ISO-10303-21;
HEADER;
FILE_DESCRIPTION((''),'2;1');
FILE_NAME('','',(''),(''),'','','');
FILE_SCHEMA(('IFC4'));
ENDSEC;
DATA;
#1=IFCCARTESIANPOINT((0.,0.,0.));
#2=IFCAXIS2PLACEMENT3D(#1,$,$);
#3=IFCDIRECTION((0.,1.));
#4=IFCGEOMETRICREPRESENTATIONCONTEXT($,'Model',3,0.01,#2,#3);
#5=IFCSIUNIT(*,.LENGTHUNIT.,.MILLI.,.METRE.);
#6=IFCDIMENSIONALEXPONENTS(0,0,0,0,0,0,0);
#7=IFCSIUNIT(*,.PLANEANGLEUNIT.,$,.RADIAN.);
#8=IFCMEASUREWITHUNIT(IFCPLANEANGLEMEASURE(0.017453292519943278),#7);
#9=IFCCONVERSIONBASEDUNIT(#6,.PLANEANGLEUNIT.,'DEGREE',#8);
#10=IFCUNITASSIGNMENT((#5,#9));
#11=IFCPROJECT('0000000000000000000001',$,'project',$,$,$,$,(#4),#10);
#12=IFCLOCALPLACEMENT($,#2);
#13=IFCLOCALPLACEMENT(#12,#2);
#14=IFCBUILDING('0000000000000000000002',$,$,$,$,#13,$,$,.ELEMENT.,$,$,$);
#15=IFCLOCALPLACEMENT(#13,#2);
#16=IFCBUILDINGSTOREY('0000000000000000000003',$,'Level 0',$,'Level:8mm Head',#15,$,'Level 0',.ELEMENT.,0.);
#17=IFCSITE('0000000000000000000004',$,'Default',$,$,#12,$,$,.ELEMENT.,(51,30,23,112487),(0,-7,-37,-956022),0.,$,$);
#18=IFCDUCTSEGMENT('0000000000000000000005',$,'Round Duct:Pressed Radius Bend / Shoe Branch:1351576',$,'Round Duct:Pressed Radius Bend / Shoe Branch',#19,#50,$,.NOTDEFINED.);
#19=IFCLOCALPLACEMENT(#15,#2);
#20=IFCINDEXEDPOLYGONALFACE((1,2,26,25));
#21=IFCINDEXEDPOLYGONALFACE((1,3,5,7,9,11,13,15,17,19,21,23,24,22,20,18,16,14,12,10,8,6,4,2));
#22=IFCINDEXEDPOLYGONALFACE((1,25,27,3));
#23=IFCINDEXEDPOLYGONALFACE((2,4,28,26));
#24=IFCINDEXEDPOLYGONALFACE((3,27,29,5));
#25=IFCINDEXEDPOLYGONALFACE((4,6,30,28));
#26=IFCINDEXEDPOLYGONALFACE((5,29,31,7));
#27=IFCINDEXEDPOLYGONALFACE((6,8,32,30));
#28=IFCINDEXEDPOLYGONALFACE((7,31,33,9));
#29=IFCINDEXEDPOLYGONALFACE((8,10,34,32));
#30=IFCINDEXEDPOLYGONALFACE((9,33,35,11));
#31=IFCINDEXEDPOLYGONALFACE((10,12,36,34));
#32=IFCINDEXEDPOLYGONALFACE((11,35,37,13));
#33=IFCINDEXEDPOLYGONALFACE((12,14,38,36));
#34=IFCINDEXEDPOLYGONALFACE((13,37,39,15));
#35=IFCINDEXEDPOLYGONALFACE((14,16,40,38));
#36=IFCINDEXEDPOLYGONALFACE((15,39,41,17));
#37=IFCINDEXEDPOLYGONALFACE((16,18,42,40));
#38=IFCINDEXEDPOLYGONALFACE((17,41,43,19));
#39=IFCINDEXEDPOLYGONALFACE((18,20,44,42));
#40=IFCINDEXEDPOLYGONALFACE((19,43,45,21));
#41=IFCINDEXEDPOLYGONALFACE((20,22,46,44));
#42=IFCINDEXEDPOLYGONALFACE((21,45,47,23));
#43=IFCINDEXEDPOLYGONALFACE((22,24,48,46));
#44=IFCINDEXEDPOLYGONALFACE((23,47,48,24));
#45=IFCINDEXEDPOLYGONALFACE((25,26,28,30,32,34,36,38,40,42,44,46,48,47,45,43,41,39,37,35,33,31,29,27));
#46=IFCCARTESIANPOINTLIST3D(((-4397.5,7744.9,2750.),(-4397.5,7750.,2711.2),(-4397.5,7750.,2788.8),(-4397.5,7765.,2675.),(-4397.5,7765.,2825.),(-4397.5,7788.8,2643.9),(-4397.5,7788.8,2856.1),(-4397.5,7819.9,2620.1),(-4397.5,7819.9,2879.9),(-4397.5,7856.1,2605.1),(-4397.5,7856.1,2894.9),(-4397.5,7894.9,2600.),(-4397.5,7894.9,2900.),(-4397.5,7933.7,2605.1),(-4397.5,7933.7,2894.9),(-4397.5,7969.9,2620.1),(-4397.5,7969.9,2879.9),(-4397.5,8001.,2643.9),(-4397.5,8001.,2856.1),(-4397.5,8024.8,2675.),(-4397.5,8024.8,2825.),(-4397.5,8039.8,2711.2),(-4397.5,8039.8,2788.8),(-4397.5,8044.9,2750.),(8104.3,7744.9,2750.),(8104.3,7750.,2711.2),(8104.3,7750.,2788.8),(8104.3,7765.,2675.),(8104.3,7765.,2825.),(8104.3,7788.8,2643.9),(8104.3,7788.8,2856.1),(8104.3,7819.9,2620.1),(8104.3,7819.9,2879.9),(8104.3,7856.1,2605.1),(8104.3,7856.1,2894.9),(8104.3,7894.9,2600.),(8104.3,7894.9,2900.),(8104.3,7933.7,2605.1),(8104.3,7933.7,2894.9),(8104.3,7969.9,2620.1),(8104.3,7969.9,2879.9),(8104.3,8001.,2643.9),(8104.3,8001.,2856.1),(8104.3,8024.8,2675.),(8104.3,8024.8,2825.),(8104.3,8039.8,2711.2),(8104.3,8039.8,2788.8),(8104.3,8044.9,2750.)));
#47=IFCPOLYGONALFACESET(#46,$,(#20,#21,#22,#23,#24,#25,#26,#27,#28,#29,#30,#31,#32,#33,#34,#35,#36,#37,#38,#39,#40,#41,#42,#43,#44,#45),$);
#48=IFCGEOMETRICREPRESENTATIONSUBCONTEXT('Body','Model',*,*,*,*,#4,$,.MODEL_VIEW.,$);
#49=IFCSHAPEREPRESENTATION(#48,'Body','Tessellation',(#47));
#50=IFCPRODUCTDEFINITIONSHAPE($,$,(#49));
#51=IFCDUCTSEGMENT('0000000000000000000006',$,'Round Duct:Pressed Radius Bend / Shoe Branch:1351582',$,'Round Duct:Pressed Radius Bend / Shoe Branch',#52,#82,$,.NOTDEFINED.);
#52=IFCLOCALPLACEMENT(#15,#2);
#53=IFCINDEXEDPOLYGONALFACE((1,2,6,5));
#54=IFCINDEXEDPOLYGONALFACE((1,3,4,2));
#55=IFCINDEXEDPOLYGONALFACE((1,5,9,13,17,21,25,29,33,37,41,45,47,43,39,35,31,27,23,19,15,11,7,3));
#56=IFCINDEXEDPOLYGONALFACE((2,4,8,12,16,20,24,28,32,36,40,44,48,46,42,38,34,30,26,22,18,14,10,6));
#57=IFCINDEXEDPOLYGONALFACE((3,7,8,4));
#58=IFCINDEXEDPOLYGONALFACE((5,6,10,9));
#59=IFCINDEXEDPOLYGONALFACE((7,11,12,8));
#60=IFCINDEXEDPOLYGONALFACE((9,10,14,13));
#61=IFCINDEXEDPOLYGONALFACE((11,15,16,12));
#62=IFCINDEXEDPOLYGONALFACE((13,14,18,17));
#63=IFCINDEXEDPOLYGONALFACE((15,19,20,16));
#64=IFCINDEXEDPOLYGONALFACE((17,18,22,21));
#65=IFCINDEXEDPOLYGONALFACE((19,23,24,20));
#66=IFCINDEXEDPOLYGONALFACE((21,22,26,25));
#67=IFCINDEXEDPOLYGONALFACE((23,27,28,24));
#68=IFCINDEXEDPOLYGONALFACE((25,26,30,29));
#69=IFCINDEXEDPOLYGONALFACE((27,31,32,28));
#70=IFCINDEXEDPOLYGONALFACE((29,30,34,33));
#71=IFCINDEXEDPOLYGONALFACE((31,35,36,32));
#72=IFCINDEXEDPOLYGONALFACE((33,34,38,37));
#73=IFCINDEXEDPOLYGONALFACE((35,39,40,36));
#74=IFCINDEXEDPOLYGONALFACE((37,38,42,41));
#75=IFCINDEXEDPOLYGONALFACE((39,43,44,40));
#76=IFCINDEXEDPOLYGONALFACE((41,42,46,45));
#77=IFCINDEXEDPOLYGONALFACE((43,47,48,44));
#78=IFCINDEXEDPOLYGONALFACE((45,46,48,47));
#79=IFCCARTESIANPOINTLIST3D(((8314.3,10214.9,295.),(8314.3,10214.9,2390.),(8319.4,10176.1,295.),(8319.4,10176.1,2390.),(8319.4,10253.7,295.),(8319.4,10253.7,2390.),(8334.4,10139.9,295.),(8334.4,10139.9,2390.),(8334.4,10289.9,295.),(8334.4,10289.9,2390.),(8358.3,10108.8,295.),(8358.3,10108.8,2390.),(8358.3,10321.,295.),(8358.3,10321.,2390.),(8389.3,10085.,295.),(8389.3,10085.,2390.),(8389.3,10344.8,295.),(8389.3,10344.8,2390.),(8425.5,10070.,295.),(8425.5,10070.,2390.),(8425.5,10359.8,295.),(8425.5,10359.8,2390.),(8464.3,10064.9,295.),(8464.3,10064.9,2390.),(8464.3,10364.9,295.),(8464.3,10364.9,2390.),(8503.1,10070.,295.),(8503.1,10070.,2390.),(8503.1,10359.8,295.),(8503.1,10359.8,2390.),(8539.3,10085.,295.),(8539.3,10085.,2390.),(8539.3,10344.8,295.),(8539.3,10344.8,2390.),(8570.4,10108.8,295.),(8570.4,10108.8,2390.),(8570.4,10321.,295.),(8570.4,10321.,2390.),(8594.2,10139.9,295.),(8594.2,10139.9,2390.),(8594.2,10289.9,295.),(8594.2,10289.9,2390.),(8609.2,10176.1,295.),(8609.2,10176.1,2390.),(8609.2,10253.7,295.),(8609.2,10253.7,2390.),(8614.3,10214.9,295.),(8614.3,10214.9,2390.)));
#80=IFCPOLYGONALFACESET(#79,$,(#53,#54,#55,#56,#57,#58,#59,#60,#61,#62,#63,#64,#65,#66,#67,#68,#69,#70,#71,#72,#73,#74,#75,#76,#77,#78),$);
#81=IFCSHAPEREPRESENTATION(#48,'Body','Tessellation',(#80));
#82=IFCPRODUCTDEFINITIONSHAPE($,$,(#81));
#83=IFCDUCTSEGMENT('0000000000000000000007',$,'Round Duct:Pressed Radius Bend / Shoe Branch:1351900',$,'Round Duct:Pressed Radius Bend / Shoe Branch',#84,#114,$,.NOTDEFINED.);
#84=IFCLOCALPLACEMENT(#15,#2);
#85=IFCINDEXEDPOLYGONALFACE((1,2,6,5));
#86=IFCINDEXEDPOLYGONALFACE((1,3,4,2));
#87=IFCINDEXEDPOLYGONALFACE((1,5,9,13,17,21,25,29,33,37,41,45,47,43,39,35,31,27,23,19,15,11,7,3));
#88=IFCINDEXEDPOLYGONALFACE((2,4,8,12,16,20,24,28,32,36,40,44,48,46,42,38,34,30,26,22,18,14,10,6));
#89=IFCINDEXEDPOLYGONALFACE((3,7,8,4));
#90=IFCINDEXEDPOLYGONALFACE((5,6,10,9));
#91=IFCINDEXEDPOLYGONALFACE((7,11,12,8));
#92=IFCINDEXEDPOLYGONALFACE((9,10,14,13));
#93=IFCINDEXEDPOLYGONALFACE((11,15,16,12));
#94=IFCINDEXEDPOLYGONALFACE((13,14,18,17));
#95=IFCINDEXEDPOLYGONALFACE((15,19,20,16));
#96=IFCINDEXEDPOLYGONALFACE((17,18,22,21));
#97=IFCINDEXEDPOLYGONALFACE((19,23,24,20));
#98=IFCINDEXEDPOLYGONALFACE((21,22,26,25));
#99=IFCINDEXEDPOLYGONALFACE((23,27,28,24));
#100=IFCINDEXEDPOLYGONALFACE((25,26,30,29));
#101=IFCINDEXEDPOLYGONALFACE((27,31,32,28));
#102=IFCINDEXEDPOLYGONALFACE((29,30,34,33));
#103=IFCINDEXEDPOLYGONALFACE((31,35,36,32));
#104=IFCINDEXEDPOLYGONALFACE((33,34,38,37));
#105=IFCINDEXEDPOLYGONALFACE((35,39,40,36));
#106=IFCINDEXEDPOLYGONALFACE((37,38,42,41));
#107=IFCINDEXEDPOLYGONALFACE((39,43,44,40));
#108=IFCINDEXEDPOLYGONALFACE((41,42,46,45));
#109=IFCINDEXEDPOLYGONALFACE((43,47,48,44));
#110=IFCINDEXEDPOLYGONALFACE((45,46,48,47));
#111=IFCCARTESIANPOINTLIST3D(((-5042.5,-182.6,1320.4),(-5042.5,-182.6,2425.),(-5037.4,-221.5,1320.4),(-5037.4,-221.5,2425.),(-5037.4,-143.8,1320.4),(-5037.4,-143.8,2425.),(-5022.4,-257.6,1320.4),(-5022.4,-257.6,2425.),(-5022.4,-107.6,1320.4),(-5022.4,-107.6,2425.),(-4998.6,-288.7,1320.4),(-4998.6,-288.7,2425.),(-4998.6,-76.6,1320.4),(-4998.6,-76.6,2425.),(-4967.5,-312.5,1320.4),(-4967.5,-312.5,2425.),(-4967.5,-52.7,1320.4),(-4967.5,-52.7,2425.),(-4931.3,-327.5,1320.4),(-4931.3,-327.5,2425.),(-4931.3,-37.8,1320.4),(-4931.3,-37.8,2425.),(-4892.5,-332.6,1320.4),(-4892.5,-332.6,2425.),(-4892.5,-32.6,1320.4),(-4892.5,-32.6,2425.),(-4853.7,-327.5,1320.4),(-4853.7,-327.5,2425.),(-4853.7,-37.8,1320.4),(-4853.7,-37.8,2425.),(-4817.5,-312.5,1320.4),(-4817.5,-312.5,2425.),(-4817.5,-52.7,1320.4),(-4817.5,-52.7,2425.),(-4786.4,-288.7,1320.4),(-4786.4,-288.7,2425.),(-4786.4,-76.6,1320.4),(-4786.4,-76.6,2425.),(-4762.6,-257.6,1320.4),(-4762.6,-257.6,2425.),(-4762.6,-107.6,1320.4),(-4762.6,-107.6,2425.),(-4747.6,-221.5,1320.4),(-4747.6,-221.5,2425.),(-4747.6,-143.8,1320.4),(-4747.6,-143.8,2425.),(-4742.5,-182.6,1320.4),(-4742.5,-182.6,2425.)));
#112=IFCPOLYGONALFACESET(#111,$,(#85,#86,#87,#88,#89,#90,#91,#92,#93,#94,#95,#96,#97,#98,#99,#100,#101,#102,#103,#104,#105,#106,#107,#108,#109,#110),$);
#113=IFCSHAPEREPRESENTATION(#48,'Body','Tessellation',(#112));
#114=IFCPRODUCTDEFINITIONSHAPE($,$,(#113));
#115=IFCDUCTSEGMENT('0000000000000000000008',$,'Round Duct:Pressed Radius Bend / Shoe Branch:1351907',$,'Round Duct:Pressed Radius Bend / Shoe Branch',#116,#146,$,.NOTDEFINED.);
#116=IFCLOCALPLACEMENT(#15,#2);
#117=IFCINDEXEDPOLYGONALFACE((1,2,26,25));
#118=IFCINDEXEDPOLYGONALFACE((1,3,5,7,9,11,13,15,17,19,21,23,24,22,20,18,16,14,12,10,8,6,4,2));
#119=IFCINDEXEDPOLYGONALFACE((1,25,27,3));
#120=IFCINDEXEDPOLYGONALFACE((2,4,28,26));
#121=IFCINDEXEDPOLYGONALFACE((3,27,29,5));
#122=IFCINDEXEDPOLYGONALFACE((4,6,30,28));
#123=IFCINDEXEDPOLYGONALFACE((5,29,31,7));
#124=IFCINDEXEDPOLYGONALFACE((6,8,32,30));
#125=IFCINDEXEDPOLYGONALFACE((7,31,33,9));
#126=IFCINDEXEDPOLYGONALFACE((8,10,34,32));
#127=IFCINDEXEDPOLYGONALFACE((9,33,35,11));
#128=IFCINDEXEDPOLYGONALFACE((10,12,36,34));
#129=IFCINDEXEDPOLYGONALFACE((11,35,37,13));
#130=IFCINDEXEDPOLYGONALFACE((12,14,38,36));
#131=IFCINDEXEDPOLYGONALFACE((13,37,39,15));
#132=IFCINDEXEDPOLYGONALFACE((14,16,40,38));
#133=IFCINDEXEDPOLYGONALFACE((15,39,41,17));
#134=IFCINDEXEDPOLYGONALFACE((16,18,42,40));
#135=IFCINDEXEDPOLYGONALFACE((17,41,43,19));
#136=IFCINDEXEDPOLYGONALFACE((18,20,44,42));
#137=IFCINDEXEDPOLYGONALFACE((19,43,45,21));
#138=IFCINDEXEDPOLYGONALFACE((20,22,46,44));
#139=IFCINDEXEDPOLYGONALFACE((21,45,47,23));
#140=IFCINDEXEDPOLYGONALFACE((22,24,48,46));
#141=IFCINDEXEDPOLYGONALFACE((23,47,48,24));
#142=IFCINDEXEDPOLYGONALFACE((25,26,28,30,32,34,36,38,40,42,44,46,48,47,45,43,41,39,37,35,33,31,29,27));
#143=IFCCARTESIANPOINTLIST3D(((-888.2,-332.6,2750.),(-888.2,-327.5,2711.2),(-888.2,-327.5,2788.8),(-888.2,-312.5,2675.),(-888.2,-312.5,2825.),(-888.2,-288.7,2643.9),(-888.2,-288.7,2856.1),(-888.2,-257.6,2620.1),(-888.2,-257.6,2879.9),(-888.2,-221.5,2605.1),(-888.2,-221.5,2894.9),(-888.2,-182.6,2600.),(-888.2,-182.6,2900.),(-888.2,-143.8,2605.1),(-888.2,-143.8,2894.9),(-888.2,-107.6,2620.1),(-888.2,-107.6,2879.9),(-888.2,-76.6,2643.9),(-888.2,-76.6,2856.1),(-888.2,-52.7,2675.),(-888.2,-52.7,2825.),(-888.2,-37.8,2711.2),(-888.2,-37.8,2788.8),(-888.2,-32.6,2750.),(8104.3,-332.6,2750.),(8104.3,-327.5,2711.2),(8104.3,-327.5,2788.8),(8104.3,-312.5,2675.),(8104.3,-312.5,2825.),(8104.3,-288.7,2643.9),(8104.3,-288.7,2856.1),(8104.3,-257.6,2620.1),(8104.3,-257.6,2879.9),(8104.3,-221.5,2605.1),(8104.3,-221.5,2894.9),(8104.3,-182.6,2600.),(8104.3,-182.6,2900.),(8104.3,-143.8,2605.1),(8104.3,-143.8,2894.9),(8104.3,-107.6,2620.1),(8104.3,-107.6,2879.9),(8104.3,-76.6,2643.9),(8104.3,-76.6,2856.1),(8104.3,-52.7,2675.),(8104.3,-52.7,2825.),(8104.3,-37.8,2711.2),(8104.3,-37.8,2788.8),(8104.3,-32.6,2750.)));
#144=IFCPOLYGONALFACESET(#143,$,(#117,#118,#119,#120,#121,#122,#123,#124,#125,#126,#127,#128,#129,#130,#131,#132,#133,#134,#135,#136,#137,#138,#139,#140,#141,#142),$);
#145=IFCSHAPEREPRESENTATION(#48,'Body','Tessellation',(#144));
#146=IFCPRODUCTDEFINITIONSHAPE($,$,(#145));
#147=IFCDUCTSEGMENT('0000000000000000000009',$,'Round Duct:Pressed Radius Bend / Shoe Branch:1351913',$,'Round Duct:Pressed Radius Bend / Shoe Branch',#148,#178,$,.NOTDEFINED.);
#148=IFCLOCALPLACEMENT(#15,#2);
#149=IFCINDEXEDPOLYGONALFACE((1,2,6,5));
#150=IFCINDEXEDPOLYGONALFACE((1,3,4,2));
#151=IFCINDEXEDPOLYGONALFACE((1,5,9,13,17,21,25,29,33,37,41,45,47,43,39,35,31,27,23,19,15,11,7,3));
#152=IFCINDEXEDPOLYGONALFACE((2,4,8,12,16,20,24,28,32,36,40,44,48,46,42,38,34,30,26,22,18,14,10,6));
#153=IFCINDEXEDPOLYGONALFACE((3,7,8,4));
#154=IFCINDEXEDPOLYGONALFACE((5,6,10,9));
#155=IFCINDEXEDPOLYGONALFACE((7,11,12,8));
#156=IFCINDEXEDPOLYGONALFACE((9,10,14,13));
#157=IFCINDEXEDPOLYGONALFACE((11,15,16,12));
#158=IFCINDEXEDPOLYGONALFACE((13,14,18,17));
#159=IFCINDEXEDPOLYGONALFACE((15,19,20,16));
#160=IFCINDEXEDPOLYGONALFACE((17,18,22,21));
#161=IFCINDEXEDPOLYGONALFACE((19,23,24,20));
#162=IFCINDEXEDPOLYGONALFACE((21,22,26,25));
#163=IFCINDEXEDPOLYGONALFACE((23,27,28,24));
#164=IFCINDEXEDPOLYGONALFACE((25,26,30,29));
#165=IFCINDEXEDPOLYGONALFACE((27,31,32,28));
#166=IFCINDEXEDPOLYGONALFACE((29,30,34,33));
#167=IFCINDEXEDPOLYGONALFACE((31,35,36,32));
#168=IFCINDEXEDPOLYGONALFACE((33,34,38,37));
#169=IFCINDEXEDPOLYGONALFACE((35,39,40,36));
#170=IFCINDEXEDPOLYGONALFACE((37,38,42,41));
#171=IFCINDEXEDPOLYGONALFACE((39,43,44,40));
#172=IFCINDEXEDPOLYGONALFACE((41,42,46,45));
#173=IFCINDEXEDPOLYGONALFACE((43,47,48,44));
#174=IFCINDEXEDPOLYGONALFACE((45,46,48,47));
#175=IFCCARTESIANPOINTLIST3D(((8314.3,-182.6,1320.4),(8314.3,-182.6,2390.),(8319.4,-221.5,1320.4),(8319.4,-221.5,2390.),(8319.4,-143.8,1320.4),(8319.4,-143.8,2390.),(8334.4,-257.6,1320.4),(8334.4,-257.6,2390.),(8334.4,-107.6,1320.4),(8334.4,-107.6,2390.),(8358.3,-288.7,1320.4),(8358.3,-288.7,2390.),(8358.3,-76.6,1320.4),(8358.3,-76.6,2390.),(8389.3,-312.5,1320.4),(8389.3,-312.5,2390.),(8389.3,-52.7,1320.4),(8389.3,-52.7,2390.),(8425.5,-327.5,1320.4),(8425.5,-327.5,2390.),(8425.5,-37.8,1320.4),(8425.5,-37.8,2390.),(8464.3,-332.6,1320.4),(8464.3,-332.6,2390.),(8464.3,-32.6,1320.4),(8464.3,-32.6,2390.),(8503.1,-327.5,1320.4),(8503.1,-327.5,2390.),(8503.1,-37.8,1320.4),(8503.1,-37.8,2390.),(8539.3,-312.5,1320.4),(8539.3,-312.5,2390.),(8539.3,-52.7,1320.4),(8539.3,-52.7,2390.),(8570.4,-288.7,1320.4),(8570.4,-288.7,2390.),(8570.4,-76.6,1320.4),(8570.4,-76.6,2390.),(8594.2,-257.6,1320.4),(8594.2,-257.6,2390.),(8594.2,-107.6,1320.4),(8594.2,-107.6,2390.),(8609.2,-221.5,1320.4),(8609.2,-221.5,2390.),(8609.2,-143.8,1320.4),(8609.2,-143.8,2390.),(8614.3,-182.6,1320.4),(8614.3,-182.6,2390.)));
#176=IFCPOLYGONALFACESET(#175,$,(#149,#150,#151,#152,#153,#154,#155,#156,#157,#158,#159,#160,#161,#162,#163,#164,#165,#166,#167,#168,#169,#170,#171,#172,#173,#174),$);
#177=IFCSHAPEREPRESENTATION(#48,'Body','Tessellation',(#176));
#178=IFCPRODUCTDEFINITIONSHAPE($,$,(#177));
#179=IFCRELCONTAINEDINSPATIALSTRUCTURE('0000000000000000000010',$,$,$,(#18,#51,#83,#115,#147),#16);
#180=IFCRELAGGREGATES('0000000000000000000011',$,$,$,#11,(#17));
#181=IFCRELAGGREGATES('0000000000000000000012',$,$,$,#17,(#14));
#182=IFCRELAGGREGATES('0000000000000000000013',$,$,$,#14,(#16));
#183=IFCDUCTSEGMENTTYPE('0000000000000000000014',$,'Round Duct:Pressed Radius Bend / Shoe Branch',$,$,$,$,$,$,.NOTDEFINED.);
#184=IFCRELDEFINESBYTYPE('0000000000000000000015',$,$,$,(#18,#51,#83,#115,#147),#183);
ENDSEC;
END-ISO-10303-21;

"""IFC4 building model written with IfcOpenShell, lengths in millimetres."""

from ifc_helpers import new_model, entity, si_unit, converted_unit, direction, frame, origin, place, context, subcontext, project, spatial, arc, indexed_curve, outline, extrude, type_object, element, save


model = new_model("IFC4")

# Units and contexts
model_context = context("Model", 3, precision=0.01, world=origin(), true_north=direction((0.0, 1.0)))
body_context = subcontext(model_context, "Body", "Model", "MODEL_VIEW")
ifc_project = project(units=[si_unit("LENGTHUNIT", "METRE", prefix="MILLI"), converted_unit("PLANEANGLEUNIT", "DEGREE", entity("IfcPlaneAngleMeasure", 0.017453292519943278), si_unit("PLANEANGLEUNIT", "RADIAN"), dimensions=[0, 0, 0, 0, 0, 0, 0])], contexts=[model_context])

# Site, building, storey
site_placement = place(None, origin())
site = spatial("IfcSite", under=ifc_project, at=site_placement, Name="Default", CompositionType="ELEMENT", RefLatitude=(51, 30, 23, 112487), RefLongitude=(0, -7, -37, -956022), RefElevation=0.0)
building_placement = place(site_placement, origin())
building = spatial("IfcBuilding", under=site, at=building_placement, CompositionType="ELEMENT")
storey_placement = place(building_placement, origin())
storey = spatial("IfcBuildingStorey", under=building, at=storey_placement, Name="Level 0", ObjectType="Level:8mm Head", LongName="Level 0", CompositionType="ELEMENT", Elevation=0.0)

# Duct segments
duct_segment_type_1 = type_object("IfcDuctSegmentType", Name="Round Duct:Pressed Radius Bend / Shoe Branch", PredefinedType="NOTDEFINED")
duct_segment_1_placement = place(storey_placement, origin())
element("IfcDuctSegment", 1, at=duct_segment_1_placement, inside=storey, type_object=duct_segment_type_1, Name="Round Duct:Pressed Radius Bend / Shoe Branch:1351576", ObjectType="Round Duct:Pressed Radius Bend / Shoe Branch", PredefinedType="NOTDEFINED", context=body_context, shape_type="SweptSolid", body=[
    extrude(outline(indexed_curve([(150.0, 0.0), (106.1, 106.1), (0.0, 150.0), (-106.1, 106.1), (-150.0, 0.0), (-106.1, -106.1), (0.0, -150.0), (106.1, -106.1)], segments=[arc(1, 2, 3), arc(3, 4, 5), arc(5, 6, 7), arc(7, 8, 1)], self_intersect=False)), frame((-4397.5, 7894.9, 2750.0), z_axis=(1.0, 0.0, 0.0), x_axis=(0.0, 1.0, 0.0)), (0.0, 0.0, 1.0), 12501.8),
])
duct_segment_2_placement = place(storey_placement, origin())
element("IfcDuctSegment", 2, at=duct_segment_2_placement, inside=storey, type_object=duct_segment_type_1, Name="Round Duct:Pressed Radius Bend / Shoe Branch:1351582", ObjectType="Round Duct:Pressed Radius Bend / Shoe Branch", PredefinedType="NOTDEFINED", context=body_context, shape_type="SweptSolid", body=[
    extrude(outline(indexed_curve([(150.0, 0.0), (106.1, 106.1), (0.0, 150.0), (-106.1, 106.1), (-150.0, 0.0), (-106.1, -106.1), (0.0, -150.0), (106.1, -106.1)], segments=[arc(1, 2, 3), arc(3, 4, 5), arc(5, 6, 7), arc(7, 8, 1)], self_intersect=False)), frame((8464.3, 10214.9, 295.0)), (0.0, 0.0, 1.0), 2095.0),
])
duct_segment_3_placement = place(storey_placement, origin())
element("IfcDuctSegment", 3, at=duct_segment_3_placement, inside=storey, type_object=duct_segment_type_1, Name="Round Duct:Pressed Radius Bend / Shoe Branch:1351900", ObjectType="Round Duct:Pressed Radius Bend / Shoe Branch", PredefinedType="NOTDEFINED", context=body_context, shape_type="SweptSolid", body=[
    extrude(outline(indexed_curve([(150.0, 0.0), (106.1, 106.1), (0.0, 150.0), (-106.1, 106.1), (-150.0, 0.0), (-106.1, -106.1), (0.0, -150.0), (106.1, -106.1)], segments=[arc(1, 2, 3), arc(3, 4, 5), arc(5, 6, 7), arc(7, 8, 1)], self_intersect=False)), frame((-4892.5, -182.6, 1320.4)), (0.0, 0.0, 1.0), 1104.6),
])
duct_segment_4_placement = place(storey_placement, origin())
element("IfcDuctSegment", 4, at=duct_segment_4_placement, inside=storey, type_object=duct_segment_type_1, Name="Round Duct:Pressed Radius Bend / Shoe Branch:1351907", ObjectType="Round Duct:Pressed Radius Bend / Shoe Branch", PredefinedType="NOTDEFINED", context=body_context, shape_type="SweptSolid", body=[
    extrude(outline(indexed_curve([(150.0, 0.0), (106.1, 106.1), (0.0, 150.0), (-106.1, 106.1), (-150.0, 0.0), (-106.1, -106.1), (0.0, -150.0), (106.1, -106.1)], segments=[arc(1, 2, 3), arc(3, 4, 5), arc(5, 6, 7), arc(7, 8, 1)], self_intersect=False)), frame((-888.2, -182.6, 2750.0), z_axis=(1.0, 0.0, 0.0), x_axis=(0.0, 1.0, 0.0)), (0.0, 0.0, 1.0), 8992.6),
])
duct_segment_5_placement = place(storey_placement, origin())
element("IfcDuctSegment", 5, at=duct_segment_5_placement, inside=storey, type_object=duct_segment_type_1, Name="Round Duct:Pressed Radius Bend / Shoe Branch:1351913", ObjectType="Round Duct:Pressed Radius Bend / Shoe Branch", PredefinedType="NOTDEFINED", context=body_context, shape_type="SweptSolid", body=[
    extrude(outline(indexed_curve([(150.0, 0.0), (106.1, 106.1), (0.0, 150.0), (-106.1, 106.1), (-150.0, 0.0), (-106.1, -106.1), (0.0, -150.0), (106.1, -106.1)], segments=[arc(1, 2, 3), arc(3, 4, 5), arc(5, 6, 7), arc(7, 8, 1)], self_intersect=False)), frame((8464.3, -182.6, 1320.4), z_axis=(0.0, 0.0, 1.0), x_axis=(-1.0, 0.0, 0.0)), (0.0, 0.0, 1.0), 1069.6),
])

save(model, "model.ifc")
